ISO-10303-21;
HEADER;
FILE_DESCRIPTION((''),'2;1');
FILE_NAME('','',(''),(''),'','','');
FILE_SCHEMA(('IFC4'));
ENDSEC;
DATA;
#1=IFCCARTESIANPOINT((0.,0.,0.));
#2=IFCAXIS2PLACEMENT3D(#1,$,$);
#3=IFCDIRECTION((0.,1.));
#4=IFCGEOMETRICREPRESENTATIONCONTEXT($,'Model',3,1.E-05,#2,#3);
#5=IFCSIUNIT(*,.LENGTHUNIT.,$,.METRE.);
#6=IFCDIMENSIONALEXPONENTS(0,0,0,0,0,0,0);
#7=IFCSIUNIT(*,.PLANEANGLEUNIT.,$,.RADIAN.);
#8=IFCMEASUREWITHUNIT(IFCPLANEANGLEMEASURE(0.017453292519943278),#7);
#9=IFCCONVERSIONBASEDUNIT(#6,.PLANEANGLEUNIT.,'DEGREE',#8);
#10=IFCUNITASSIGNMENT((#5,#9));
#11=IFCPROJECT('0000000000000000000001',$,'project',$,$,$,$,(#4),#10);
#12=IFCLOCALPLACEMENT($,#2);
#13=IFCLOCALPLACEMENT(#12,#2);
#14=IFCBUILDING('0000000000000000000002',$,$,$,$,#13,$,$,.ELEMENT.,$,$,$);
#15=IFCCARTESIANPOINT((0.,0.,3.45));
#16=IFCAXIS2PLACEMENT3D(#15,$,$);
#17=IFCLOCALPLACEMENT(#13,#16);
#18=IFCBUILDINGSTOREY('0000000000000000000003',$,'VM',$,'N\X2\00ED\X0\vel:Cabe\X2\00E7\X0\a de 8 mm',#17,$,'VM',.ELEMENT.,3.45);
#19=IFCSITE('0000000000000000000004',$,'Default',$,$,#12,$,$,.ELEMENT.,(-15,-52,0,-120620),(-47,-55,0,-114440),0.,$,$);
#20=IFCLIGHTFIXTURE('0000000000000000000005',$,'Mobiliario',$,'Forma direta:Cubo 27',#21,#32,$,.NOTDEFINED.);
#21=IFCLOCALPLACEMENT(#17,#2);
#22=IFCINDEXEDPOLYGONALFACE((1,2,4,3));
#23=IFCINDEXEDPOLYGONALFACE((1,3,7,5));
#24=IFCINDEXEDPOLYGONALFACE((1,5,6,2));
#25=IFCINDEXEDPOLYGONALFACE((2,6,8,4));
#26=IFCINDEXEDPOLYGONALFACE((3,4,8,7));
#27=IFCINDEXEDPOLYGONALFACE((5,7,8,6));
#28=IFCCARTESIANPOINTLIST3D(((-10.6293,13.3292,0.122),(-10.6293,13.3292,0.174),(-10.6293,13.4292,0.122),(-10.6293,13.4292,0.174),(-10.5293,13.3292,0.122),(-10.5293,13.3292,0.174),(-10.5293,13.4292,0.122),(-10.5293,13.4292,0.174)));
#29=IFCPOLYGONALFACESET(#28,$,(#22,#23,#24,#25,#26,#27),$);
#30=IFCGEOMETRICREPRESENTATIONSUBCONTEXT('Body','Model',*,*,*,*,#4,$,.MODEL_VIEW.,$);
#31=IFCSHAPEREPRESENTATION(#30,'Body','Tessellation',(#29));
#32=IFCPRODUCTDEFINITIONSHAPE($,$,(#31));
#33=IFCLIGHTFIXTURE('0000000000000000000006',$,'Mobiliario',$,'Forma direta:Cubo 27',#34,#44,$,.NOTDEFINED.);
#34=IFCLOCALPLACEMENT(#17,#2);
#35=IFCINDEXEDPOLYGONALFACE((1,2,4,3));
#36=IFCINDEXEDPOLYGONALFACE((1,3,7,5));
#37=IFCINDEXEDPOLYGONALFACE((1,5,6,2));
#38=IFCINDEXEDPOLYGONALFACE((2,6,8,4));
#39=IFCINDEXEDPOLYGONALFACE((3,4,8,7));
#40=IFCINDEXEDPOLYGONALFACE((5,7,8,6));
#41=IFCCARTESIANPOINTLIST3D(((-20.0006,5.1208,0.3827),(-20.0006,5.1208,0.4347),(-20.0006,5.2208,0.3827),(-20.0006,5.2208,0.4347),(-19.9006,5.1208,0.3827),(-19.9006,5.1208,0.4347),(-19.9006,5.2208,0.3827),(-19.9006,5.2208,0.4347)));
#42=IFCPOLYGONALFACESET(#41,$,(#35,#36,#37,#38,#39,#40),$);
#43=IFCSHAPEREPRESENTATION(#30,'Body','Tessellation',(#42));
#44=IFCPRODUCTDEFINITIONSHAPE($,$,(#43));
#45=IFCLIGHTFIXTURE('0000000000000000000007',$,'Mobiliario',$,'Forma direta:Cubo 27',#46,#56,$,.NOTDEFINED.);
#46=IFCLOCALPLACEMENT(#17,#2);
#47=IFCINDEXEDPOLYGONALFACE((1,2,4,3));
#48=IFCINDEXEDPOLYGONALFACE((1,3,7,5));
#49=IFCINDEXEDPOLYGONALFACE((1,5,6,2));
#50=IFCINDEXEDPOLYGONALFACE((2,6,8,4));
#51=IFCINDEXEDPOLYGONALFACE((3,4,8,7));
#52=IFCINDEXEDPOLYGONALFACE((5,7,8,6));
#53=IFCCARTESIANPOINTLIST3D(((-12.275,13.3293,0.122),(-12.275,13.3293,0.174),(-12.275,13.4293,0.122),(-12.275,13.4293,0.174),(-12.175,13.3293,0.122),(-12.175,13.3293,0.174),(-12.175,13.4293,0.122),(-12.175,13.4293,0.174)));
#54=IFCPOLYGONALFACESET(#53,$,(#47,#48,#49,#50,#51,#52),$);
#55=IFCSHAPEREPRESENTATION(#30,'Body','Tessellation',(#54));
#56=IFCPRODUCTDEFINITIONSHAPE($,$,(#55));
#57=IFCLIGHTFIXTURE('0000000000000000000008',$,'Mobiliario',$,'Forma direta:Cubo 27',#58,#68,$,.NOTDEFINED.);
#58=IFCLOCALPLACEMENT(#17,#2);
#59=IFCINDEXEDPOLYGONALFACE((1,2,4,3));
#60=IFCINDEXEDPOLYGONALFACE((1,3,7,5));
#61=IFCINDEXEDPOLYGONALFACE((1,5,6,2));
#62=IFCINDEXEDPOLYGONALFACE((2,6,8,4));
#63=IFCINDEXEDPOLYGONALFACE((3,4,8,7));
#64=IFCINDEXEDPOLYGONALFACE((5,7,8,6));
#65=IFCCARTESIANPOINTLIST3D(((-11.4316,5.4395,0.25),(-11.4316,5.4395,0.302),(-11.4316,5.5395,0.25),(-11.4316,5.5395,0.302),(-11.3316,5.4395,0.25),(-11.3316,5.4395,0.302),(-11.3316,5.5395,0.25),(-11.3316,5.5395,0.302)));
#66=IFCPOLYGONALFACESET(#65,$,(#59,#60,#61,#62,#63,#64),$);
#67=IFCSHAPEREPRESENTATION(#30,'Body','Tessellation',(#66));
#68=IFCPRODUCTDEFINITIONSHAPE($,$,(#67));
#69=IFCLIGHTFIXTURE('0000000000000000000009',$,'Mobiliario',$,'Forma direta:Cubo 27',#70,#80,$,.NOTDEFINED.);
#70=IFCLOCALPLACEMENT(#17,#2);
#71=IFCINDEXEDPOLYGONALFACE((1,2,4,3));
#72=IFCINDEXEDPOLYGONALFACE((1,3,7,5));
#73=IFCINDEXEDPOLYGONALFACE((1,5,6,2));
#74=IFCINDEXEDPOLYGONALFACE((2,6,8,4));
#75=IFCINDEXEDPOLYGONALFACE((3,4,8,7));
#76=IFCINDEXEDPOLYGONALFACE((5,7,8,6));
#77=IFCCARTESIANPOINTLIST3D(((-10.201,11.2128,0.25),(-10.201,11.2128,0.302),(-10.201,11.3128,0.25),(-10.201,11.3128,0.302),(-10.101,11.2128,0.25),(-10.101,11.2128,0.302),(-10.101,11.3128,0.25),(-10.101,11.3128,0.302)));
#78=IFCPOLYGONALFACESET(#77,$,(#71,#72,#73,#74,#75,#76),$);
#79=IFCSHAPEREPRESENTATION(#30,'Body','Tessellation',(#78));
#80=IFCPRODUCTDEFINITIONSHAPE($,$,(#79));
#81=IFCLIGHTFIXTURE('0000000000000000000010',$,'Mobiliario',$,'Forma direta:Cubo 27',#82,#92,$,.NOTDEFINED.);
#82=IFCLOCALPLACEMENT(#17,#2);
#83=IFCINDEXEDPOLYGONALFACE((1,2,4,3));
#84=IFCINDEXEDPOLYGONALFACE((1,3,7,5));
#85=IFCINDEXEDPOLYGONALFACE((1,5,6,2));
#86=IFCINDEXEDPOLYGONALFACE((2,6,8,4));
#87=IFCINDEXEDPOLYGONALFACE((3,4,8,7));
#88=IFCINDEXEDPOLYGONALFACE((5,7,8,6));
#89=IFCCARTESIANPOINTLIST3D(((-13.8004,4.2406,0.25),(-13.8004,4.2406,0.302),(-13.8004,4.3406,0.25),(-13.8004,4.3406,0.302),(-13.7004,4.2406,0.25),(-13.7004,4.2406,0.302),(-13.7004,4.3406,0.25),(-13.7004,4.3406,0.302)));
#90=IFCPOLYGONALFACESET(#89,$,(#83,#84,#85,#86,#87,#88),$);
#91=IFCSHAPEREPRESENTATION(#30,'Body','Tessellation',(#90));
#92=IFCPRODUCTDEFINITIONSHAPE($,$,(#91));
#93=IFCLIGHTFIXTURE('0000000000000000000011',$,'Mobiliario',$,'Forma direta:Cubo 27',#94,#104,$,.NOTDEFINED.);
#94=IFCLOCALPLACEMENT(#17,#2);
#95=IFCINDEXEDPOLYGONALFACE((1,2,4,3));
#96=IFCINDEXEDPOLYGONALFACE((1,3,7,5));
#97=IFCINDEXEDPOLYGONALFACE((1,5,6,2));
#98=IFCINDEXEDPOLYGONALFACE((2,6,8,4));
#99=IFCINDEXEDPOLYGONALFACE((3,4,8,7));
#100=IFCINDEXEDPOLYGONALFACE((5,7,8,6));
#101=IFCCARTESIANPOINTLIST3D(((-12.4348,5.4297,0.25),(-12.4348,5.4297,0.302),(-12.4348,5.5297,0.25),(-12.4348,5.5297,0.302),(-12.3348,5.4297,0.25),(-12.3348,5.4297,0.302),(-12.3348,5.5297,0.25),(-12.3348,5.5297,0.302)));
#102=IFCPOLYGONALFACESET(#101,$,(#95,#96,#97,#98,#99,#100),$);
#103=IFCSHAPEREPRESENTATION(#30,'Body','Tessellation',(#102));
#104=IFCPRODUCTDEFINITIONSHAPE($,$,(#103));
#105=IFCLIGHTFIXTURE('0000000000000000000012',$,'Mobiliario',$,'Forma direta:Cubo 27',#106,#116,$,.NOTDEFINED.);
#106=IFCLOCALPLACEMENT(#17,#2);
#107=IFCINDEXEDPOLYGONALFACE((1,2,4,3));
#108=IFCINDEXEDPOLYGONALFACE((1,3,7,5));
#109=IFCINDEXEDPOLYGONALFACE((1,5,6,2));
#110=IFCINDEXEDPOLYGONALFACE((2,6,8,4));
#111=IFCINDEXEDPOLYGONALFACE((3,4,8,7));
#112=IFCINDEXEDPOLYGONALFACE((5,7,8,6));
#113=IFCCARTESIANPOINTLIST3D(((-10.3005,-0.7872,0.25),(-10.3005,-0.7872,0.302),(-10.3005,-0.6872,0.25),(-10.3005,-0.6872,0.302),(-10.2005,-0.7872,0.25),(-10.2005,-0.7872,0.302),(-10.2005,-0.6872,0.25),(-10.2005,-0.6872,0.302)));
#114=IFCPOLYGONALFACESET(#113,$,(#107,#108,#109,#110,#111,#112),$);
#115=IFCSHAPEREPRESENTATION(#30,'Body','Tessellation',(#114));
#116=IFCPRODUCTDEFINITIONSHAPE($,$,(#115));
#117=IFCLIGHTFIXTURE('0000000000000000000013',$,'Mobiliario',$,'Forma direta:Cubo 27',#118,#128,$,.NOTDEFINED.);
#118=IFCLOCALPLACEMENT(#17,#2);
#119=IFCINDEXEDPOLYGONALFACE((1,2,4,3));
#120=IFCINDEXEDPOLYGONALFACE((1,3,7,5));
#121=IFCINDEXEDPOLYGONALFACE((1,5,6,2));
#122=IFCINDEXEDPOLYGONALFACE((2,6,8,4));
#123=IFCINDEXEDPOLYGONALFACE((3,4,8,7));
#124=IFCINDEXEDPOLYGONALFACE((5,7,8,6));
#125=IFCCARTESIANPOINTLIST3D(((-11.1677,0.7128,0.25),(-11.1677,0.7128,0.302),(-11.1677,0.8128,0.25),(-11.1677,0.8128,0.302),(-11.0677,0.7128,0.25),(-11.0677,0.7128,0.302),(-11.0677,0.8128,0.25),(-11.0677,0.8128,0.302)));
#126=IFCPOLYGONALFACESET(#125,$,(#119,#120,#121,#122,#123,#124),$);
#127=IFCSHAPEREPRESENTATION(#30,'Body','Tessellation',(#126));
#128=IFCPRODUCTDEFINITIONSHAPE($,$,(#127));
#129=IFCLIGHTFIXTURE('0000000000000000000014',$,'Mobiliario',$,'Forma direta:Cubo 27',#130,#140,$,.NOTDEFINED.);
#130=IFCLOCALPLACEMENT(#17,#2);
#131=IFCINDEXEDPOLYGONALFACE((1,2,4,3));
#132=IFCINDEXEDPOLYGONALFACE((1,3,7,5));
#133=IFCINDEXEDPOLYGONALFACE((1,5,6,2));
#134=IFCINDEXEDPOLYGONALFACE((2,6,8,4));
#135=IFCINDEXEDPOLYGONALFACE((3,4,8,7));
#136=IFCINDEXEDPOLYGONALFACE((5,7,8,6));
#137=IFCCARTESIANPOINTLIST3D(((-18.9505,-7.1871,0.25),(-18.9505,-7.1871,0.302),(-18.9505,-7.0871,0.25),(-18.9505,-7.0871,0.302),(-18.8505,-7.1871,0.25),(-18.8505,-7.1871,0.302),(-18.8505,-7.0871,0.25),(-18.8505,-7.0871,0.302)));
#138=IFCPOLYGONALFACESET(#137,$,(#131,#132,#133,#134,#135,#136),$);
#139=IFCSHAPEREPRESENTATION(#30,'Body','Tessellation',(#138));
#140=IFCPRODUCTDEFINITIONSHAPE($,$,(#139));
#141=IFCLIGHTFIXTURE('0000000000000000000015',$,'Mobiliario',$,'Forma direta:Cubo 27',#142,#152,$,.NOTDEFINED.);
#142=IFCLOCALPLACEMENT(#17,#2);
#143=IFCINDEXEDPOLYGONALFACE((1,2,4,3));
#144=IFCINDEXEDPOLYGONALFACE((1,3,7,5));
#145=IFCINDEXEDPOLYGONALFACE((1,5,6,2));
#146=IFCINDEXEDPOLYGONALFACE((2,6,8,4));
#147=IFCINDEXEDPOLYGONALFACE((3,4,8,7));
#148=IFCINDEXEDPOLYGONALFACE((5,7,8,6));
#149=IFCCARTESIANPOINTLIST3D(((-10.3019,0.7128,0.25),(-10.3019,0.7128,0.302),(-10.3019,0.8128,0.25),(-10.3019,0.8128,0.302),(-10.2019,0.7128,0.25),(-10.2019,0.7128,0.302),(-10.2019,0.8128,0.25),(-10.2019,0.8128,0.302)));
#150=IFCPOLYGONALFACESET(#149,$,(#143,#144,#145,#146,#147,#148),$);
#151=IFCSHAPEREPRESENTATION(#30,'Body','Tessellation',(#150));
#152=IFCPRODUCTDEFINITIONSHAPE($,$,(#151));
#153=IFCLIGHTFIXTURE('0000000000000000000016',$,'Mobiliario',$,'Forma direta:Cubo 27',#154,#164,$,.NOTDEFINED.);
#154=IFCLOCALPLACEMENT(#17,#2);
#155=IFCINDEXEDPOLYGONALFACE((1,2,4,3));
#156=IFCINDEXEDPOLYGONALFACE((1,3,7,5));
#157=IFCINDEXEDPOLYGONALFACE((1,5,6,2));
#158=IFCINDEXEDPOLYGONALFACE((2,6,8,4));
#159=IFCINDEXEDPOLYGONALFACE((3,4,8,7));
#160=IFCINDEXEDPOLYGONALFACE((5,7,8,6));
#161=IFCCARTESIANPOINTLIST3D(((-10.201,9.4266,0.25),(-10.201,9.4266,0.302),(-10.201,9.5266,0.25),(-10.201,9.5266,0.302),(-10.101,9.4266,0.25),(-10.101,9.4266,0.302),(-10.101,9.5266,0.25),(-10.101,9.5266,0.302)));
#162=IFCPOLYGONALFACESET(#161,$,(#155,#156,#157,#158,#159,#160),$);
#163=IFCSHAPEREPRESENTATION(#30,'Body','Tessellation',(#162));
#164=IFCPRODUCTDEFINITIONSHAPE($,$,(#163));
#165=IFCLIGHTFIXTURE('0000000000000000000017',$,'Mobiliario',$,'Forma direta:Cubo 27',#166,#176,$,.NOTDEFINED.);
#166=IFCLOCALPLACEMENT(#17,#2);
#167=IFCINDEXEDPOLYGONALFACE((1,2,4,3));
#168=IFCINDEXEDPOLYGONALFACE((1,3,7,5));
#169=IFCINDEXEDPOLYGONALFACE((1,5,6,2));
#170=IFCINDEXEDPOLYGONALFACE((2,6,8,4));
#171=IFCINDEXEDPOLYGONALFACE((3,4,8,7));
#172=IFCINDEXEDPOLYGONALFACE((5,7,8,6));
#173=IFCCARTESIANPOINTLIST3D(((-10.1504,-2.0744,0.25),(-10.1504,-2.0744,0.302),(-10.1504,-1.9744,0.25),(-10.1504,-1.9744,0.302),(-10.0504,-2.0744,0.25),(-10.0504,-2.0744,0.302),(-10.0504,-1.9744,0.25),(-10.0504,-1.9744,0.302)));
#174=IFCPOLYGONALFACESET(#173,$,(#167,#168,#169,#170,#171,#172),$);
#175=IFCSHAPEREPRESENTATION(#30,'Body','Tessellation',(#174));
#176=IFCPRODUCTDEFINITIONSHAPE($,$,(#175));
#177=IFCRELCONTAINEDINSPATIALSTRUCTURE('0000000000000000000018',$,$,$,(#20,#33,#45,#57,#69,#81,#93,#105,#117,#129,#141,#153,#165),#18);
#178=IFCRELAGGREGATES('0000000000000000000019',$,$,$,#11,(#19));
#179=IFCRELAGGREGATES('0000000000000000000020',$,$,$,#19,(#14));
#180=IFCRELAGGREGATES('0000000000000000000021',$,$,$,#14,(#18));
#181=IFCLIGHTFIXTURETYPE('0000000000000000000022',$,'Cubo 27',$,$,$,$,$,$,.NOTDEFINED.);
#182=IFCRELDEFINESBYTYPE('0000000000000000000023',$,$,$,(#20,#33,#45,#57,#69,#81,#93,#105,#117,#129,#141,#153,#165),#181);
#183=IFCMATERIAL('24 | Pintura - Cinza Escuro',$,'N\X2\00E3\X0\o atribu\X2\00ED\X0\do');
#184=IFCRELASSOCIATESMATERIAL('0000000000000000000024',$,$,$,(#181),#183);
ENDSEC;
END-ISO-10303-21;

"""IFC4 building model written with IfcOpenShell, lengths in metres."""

from ifc_helpers import new_model, entity, si_unit, converted_unit, direction, frame, origin, place, context, subcontext, project, spatial, indexed_curve, outline, extrude, material, type_object, element, save


model = new_model("IFC4")

# Units and contexts
model_context = context("Model", 3, precision=1e-05, world=origin(), true_north=direction((0.0, 1.0)))
body_context = subcontext(model_context, "Body", "Model", "MODEL_VIEW")
ifc_project = project(units=[si_unit("LENGTHUNIT", "METRE"), converted_unit("PLANEANGLEUNIT", "DEGREE", entity("IfcPlaneAngleMeasure", 0.017453292519943278), si_unit("PLANEANGLEUNIT", "RADIAN"), dimensions=[0, 0, 0, 0, 0, 0, 0])], contexts=[model_context])

# Site, building, storey
site_placement = place(None, origin())
site = spatial("IfcSite", under=ifc_project, at=site_placement, Name="Default", CompositionType="ELEMENT", RefLatitude=(-15, -52, 0, -120620), RefLongitude=(-47, -55, 0, -114440), RefElevation=0.0)
building_placement = place(site_placement, origin())
building = spatial("IfcBuilding", under=site, at=building_placement, CompositionType="ELEMENT")
storey_placement = place(building_placement, frame((0.0, 0.0, 3.45)))
storey = spatial("IfcBuildingStorey", under=building, at=storey_placement, Name="VM", ObjectType="Nível:Cabeça de 8 mm", LongName="VM", CompositionType="ELEMENT", Elevation=3.45)

# Light fixtures
ifc_material_1 = material(Name="24 | Pintura - Cinza Escuro", Category="Não atribuído")
light_fixture_type_1 = type_object("IfcLightFixtureType", Name="Cubo 27", PredefinedType="NOTDEFINED", material=ifc_material_1)
light_fixture_1_placement = place(storey_placement, origin())
element("IfcLightFixture", 1, at=light_fixture_1_placement, inside=storey, type_object=light_fixture_type_1, Name="Mobiliario", ObjectType="Forma direta:Cubo 27", PredefinedType="NOTDEFINED", context=body_context, shape_type="SweptSolid", body=[
    extrude(outline(indexed_curve([(-0.05, -0.05), (0.05, -0.05), (0.05, 0.05), (-0.05, 0.05), (-0.05, -0.05)], self_intersect=False)), frame((-10.5793, 13.3792, 0.122), z_axis=(0.0, 0.0, 1.0), x_axis=(-0.000013, -1.0, 0.0)), (0.0, 0.0, 1.0), 0.052),
])
light_fixture_2_placement = place(storey_placement, origin())
element("IfcLightFixture", 2, at=light_fixture_2_placement, inside=storey, type_object=light_fixture_type_1, Name="Mobiliario", ObjectType="Forma direta:Cubo 27", PredefinedType="NOTDEFINED", context=body_context, shape_type="SweptSolid", body=[
    extrude(outline(indexed_curve([(-0.05, -0.05), (0.05, -0.05), (0.05, 0.05), (-0.05, 0.05), (-0.05, -0.05)], self_intersect=False)), frame((-19.9506, 5.1708, 0.3827), z_axis=(0.0, 0.0, 1.0), x_axis=(-0.000013, -1.0, 0.0)), (0.0, 0.0, 1.0), 0.052),
])
light_fixture_3_placement = place(storey_placement, origin())
element("IfcLightFixture", 3, at=light_fixture_3_placement, inside=storey, type_object=light_fixture_type_1, Name="Mobiliario", ObjectType="Forma direta:Cubo 27", PredefinedType="NOTDEFINED", context=body_context, shape_type="SweptSolid", body=[
    extrude(outline(indexed_curve([(-0.05, -0.05), (0.05, -0.05), (0.05, 0.05), (-0.05, 0.05), (-0.05, -0.05)], self_intersect=False)), frame((-12.225, 13.3793, 0.122), z_axis=(0.0, 0.0, 1.0), x_axis=(-0.000013, -1.0, 0.0)), (0.0, 0.0, 1.0), 0.052),
])
light_fixture_4_placement = place(storey_placement, origin())
element("IfcLightFixture", 4, at=light_fixture_4_placement, inside=storey, type_object=light_fixture_type_1, Name="Mobiliario", ObjectType="Forma direta:Cubo 27", PredefinedType="NOTDEFINED", context=body_context, shape_type="SweptSolid", body=[
    extrude(outline(indexed_curve([(-0.05, -0.05), (0.05, -0.05), (0.05, 0.05), (-0.05, 0.05), (-0.05, -0.05)], self_intersect=False)), frame((-11.3816, 5.4895, 0.25), z_axis=(0.0, 0.0, 1.0), x_axis=(-0.000013, -1.0, 0.0)), (0.0, 0.0, 1.0), 0.052),
])
light_fixture_5_placement = place(storey_placement, origin())
element("IfcLightFixture", 5, at=light_fixture_5_placement, inside=storey, type_object=light_fixture_type_1, Name="Mobiliario", ObjectType="Forma direta:Cubo 27", PredefinedType="NOTDEFINED", context=body_context, shape_type="SweptSolid", body=[
    extrude(outline(indexed_curve([(-0.05, -0.05), (0.05, -0.05), (0.05, 0.05), (-0.05, 0.05), (-0.05, -0.05)], self_intersect=False)), frame((-10.151, 11.2628, 0.25), z_axis=(0.0, 0.0, 1.0), x_axis=(-0.000013, -1.0, 0.0)), (0.0, 0.0, 1.0), 0.052),
])
light_fixture_6_placement = place(storey_placement, origin())
element("IfcLightFixture", 6, at=light_fixture_6_placement, inside=storey, type_object=light_fixture_type_1, Name="Mobiliario", ObjectType="Forma direta:Cubo 27", PredefinedType="NOTDEFINED", context=body_context, shape_type="SweptSolid", body=[
    extrude(outline(indexed_curve([(-0.05, -0.05), (0.05, -0.05), (0.05, 0.05), (-0.05, 0.05), (-0.05, -0.05)], self_intersect=False)), frame((-13.7504, 4.2906, 0.25), z_axis=(0.0, 0.0, 1.0), x_axis=(-0.000013, -1.0, 0.0)), (0.0, 0.0, 1.0), 0.052),
])
light_fixture_7_placement = place(storey_placement, origin())
element("IfcLightFixture", 7, at=light_fixture_7_placement, inside=storey, type_object=light_fixture_type_1, Name="Mobiliario", ObjectType="Forma direta:Cubo 27", PredefinedType="NOTDEFINED", context=body_context, shape_type="SweptSolid", body=[
    extrude(outline(indexed_curve([(-0.05, -0.05), (0.05, -0.05), (0.05, 0.05), (-0.05, 0.05), (-0.05, -0.05)], self_intersect=False)), frame((-12.3848, 5.4797, 0.25), z_axis=(0.0, 0.0, 1.0), x_axis=(-0.000013, -1.0, 0.0)), (0.0, 0.0, 1.0), 0.052),
])
light_fixture_8_placement = place(storey_placement, origin())
element("IfcLightFixture", 8, at=light_fixture_8_placement, inside=storey, type_object=light_fixture_type_1, Name="Mobiliario", ObjectType="Forma direta:Cubo 27", PredefinedType="NOTDEFINED", context=body_context, shape_type="SweptSolid", body=[
    extrude(outline(indexed_curve([(-0.05, -0.05), (0.05, -0.05), (0.05, 0.05), (-0.05, 0.05), (-0.05, -0.05)], self_intersect=False)), frame((-10.2505, -0.7372, 0.25), z_axis=(0.0, 0.0, 1.0), x_axis=(-0.000013, -1.0, 0.0)), (0.0, 0.0, 1.0), 0.052),
])
light_fixture_9_placement = place(storey_placement, origin())
element("IfcLightFixture", 9, at=light_fixture_9_placement, inside=storey, type_object=light_fixture_type_1, Name="Mobiliario", ObjectType="Forma direta:Cubo 27", PredefinedType="NOTDEFINED", context=body_context, shape_type="SweptSolid", body=[
    extrude(outline(indexed_curve([(-0.05, -0.05), (0.05, -0.05), (0.05, 0.05), (-0.05, 0.05), (-0.05, -0.05)], self_intersect=False)), frame((-11.1177, 0.7628, 0.25), z_axis=(0.0, 0.0, 1.0), x_axis=(-0.000013, -1.0, 0.0)), (0.0, 0.0, 1.0), 0.052),
])
light_fixture_10_placement = place(storey_placement, origin())
element("IfcLightFixture", 10, at=light_fixture_10_placement, inside=storey, type_object=light_fixture_type_1, Name="Mobiliario", ObjectType="Forma direta:Cubo 27", PredefinedType="NOTDEFINED", context=body_context, shape_type="SweptSolid", body=[
    extrude(outline(indexed_curve([(-0.05, -0.05), (0.05, -0.05), (0.05, 0.05), (-0.05, 0.05), (-0.05, -0.05)], self_intersect=False)), frame((-18.9005, -7.1371, 0.25), z_axis=(0.0, 0.0, 1.0), x_axis=(-0.000013, -1.0, 0.0)), (0.0, 0.0, 1.0), 0.052),
])
light_fixture_11_placement = place(storey_placement, origin())
element("IfcLightFixture", 11, at=light_fixture_11_placement, inside=storey, type_object=light_fixture_type_1, Name="Mobiliario", ObjectType="Forma direta:Cubo 27", PredefinedType="NOTDEFINED", context=body_context, shape_type="SweptSolid", body=[
    extrude(outline(indexed_curve([(-0.05, -0.05), (0.05, -0.05), (0.05, 0.05), (-0.05, 0.05), (-0.05, -0.05)], self_intersect=False)), frame((-10.2519, 0.7628, 0.25), z_axis=(0.0, 0.0, 1.0), x_axis=(-0.000013, -1.0, 0.0)), (0.0, 0.0, 1.0), 0.052),
])
light_fixture_12_placement = place(storey_placement, origin())
element("IfcLightFixture", 12, at=light_fixture_12_placement, inside=storey, type_object=light_fixture_type_1, Name="Mobiliario", ObjectType="Forma direta:Cubo 27", PredefinedType="NOTDEFINED", context=body_context, shape_type="SweptSolid", body=[
    extrude(outline(indexed_curve([(-0.05, -0.05), (0.05, -0.05), (0.05, 0.05), (-0.05, 0.05), (-0.05, -0.05)], self_intersect=False)), frame((-10.151, 9.4766, 0.25), z_axis=(0.0, 0.0, 1.0), x_axis=(-0.000013, -1.0, 0.0)), (0.0, 0.0, 1.0), 0.052),
])
light_fixture_13_placement = place(storey_placement, origin())
element("IfcLightFixture", 13, at=light_fixture_13_placement, inside=storey, type_object=light_fixture_type_1, Name="Mobiliario", ObjectType="Forma direta:Cubo 27", PredefinedType="NOTDEFINED", context=body_context, shape_type="SweptSolid", body=[
    extrude(outline(indexed_curve([(-0.05, -0.05), (0.05, -0.05), (0.05, 0.05), (-0.05, 0.05), (-0.05, -0.05)], self_intersect=False)), frame((-10.1004, -2.0244, 0.25), z_axis=(0.0, 0.0, 1.0), x_axis=(-0.000013, -1.0, 0.0)), (0.0, 0.0, 1.0), 0.052),
])

save(model, "model.ifc")
